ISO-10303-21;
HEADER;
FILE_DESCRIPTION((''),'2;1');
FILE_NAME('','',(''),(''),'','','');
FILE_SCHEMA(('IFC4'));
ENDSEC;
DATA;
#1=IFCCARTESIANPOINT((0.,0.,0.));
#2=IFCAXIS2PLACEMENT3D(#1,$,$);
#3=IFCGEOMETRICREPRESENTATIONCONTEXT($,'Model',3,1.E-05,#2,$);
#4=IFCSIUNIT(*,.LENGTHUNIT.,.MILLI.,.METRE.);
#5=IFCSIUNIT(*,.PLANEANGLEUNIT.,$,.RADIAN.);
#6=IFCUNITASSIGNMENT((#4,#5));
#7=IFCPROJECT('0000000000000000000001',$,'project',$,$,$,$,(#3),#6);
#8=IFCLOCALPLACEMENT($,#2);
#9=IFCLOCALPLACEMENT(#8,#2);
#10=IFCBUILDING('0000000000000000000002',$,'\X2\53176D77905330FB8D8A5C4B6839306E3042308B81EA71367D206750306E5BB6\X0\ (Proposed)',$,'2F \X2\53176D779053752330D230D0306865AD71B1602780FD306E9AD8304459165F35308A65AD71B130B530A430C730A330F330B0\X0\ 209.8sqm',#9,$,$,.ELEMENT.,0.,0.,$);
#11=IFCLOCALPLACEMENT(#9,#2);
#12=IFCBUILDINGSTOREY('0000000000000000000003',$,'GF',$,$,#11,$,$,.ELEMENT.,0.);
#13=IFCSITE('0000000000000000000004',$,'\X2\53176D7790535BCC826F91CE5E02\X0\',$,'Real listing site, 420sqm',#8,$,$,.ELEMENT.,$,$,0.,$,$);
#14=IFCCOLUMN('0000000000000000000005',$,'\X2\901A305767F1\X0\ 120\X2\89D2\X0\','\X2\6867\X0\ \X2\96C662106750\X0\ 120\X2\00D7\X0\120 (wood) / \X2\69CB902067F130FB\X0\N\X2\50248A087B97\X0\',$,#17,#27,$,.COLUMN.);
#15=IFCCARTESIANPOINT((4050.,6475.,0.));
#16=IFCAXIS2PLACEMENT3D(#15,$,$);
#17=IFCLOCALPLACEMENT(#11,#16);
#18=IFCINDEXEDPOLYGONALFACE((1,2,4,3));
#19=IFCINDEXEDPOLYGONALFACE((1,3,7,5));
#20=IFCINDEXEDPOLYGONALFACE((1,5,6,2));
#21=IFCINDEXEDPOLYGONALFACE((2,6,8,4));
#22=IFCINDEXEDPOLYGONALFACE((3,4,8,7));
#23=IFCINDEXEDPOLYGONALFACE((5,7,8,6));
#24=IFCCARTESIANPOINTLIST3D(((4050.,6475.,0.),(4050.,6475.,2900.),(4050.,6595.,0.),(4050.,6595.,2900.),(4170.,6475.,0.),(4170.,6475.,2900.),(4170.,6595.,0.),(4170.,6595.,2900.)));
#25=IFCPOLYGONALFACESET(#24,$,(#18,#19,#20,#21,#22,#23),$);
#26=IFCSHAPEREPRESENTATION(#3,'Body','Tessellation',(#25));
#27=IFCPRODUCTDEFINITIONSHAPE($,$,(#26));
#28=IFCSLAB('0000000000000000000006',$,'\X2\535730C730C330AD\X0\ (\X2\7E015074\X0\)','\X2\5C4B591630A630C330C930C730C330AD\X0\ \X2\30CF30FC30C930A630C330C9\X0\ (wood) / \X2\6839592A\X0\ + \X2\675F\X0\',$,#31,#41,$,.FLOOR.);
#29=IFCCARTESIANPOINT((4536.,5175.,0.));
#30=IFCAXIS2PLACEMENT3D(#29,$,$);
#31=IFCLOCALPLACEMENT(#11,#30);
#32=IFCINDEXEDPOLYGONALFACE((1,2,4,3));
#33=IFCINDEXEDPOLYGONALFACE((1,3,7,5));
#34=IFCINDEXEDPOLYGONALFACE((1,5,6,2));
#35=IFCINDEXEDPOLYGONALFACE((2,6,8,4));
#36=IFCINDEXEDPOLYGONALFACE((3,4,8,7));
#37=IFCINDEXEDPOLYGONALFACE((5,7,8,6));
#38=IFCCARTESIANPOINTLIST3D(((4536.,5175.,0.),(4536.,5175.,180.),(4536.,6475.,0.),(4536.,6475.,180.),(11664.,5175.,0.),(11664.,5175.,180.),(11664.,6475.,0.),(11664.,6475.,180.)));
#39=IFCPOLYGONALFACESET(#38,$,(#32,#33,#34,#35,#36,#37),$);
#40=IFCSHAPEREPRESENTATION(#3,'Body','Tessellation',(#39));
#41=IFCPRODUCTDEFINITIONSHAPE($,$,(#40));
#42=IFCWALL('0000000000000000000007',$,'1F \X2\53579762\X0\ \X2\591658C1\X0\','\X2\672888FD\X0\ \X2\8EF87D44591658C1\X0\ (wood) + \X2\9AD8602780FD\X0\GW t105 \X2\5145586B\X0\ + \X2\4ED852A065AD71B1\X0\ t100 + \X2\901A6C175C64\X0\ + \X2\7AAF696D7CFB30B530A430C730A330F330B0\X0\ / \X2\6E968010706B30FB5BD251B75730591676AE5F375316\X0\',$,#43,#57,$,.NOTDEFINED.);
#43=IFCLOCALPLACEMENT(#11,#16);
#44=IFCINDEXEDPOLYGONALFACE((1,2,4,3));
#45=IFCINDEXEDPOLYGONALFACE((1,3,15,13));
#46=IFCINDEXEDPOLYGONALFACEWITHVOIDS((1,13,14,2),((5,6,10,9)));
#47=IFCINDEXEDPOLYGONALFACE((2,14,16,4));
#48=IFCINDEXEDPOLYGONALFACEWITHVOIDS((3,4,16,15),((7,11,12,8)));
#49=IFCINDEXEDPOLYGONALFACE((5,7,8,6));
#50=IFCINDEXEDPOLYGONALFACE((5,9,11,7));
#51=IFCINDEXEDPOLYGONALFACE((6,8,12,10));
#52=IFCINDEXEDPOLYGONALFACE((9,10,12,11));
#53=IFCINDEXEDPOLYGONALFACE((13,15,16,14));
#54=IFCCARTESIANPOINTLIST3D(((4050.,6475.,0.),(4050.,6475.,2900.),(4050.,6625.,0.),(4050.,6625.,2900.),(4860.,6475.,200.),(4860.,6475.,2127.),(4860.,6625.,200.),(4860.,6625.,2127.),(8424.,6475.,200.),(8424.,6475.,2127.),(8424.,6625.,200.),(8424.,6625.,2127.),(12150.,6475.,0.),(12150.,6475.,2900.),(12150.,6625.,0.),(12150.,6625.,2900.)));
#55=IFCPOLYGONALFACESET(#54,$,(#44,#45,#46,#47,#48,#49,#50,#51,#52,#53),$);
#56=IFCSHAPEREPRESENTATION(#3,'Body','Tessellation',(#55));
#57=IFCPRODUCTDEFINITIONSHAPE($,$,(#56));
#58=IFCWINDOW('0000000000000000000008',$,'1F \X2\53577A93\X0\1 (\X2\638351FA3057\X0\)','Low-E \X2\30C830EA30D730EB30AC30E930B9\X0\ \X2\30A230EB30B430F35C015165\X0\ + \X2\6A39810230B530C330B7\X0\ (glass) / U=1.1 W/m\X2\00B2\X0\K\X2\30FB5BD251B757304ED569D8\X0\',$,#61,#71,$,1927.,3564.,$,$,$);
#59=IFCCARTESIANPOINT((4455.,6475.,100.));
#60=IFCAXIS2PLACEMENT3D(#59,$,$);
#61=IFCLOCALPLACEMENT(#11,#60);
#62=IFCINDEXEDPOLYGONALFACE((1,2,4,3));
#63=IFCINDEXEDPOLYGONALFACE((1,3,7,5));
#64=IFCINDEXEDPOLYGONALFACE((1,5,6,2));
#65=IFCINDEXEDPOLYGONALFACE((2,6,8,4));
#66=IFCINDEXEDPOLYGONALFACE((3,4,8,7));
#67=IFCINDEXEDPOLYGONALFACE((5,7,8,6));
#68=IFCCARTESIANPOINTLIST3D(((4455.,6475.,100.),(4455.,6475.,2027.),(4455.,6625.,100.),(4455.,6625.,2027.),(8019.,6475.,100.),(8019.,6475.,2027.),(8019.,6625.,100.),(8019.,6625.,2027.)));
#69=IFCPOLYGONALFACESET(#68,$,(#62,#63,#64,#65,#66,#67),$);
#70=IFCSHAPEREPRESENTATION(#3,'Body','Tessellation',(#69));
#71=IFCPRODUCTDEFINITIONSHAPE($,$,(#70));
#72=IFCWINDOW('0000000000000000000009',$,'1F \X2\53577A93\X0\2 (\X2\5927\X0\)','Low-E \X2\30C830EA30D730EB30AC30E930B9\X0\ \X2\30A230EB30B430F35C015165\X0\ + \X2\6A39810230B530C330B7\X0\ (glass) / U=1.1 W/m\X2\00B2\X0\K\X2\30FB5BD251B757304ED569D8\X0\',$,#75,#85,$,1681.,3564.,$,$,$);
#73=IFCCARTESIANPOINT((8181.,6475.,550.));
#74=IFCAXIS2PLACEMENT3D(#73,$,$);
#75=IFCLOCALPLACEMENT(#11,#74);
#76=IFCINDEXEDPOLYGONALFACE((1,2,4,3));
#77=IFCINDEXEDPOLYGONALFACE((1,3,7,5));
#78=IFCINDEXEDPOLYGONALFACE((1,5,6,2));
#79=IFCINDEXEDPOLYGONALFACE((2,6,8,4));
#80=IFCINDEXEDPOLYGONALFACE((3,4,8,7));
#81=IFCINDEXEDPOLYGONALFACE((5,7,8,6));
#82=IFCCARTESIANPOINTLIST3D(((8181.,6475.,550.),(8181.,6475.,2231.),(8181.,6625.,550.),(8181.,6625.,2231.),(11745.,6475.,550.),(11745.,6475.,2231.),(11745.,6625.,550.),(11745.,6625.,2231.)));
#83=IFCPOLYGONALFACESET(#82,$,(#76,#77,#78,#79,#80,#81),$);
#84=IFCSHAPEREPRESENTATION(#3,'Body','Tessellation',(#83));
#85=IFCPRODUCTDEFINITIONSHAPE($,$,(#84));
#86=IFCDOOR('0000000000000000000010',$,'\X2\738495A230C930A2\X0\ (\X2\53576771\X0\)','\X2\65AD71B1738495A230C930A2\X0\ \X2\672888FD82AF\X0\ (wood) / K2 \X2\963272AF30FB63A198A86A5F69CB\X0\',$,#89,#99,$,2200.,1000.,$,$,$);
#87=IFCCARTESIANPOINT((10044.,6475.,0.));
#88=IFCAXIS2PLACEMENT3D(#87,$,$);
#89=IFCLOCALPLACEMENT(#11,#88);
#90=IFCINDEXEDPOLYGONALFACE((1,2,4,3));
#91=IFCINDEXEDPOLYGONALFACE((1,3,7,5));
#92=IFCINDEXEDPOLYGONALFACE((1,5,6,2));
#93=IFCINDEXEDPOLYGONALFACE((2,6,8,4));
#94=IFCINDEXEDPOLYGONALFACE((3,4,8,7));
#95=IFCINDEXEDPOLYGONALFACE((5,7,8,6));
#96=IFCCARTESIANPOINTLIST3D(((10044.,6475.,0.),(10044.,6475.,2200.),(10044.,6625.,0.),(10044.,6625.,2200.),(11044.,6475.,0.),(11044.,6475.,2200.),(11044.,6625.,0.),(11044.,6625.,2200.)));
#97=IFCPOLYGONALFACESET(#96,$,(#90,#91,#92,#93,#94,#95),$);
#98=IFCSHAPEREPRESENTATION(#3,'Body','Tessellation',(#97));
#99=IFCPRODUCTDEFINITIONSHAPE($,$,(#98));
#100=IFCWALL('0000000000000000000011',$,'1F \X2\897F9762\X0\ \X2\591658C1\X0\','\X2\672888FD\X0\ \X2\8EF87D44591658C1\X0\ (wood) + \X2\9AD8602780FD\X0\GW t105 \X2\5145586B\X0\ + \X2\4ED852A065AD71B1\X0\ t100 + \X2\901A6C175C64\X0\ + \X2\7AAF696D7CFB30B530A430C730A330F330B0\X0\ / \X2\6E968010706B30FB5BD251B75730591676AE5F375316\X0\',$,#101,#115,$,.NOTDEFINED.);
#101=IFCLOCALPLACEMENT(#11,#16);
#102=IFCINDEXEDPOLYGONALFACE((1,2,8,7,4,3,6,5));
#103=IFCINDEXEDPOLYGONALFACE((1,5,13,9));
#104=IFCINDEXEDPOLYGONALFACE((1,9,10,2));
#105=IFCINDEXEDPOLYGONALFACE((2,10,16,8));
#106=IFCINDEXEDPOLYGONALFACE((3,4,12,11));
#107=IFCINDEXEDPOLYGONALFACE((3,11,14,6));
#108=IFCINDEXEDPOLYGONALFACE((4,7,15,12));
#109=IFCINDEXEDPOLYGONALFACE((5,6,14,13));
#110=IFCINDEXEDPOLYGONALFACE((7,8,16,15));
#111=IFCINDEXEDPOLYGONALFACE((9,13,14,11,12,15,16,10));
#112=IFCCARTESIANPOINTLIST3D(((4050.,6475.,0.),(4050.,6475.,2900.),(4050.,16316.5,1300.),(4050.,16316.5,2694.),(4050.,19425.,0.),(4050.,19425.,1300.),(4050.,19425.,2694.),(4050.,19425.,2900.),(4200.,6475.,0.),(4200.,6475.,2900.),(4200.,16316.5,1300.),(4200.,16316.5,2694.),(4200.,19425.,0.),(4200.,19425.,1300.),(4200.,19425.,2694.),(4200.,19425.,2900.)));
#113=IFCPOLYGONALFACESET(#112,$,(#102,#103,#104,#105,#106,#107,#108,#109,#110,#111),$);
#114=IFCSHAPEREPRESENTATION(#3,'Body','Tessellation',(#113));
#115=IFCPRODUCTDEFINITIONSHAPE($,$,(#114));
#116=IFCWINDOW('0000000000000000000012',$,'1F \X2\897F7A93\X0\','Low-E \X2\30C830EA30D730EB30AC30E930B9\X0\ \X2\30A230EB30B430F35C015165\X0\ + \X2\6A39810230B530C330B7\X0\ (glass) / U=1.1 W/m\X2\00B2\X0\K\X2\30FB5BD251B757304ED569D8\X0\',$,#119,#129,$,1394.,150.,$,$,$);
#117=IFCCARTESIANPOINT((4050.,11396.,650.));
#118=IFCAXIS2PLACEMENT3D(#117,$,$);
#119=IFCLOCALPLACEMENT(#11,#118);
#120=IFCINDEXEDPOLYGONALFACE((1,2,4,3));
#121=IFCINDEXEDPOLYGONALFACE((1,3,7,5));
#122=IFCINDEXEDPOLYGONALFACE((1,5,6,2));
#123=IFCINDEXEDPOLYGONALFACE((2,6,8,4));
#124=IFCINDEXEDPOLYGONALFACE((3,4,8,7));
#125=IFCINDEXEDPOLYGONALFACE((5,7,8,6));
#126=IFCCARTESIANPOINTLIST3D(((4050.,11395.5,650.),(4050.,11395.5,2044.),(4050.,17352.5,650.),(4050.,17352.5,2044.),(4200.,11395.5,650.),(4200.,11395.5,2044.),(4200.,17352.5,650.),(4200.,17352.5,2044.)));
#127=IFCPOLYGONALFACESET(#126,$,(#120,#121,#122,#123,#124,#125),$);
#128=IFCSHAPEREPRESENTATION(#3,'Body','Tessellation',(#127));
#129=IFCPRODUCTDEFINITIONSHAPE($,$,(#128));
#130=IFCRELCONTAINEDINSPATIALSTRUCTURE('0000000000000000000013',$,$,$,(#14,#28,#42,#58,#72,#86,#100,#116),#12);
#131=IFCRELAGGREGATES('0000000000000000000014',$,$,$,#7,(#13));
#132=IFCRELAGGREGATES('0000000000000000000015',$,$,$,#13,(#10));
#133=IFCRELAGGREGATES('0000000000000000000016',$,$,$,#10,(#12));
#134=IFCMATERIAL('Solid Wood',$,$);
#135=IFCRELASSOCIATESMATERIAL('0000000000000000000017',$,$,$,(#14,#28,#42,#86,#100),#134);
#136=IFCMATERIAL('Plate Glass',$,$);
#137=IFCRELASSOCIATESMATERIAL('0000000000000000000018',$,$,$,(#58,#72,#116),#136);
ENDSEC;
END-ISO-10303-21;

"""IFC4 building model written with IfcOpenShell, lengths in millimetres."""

from ifc_helpers import new_model, si_unit, frame, frame_2d, origin, place, context, project, spatial, rectangle, extrude, material, element, fill, save


model = new_model("IFC4")

# Units and contexts
model_context = context("Model", 3, precision=1e-05, world=origin())
ifc_project = project(units=[si_unit("LENGTHUNIT", "METRE", prefix="MILLI"), si_unit("PLANEANGLEUNIT", "RADIAN")], contexts=[model_context])

# Site, building, storey
site_placement = place(None, origin())
site = spatial("IfcSite", under=ifc_project, at=site_placement, Name="北海道富良野市", ObjectType="Real listing site, 420sqm", CompositionType="ELEMENT", RefElevation=0.0)
building_placement = place(site_placement, origin())
building = spatial("IfcBuilding", under=site, at=building_placement, Name="北海道・越屋根のある自然素材の家 (Proposed)", ObjectType="2F 北海道産ヒバと断熱性能の高い外張り断熱サイディング 209.8sqm", CompositionType="ELEMENT", ElevationOfRefHeight=0.0, ElevationOfTerrain=0.0)
storey_placement = place(building_placement, origin())
storey = spatial("IfcBuildingStorey", under=building, at=storey_placement, Name="GF", CompositionType="ELEMENT", Elevation=0.0)

# Column
ifc_material_1 = material(Name="Solid Wood")
column_placement = place(storey_placement, frame((4050.0, 6475.0, 0.0)))
element("IfcColumn", 1, at=column_placement, inside=storey, material=ifc_material_1, Name="通し柱 120角", Description="桧 集成材 120×120 (wood) / 構造柱・N値計算", PredefinedType="COLUMN", context=model_context, shape_type="SweptSolid", body=[
    extrude(rectangle(XDim=120.0, YDim=120.0, at=frame_2d((60.0, 60.0))), frame((4050.0, 6475.0, 0.0)), (0.0, 0.0, 1.0), 2900.0),
])

# Slab
slab_1_placement = place(storey_placement, frame((4536.0, 5175.0, 0.0)))
element("IfcSlab", 2, at=slab_1_placement, inside=storey, material=ifc_material_1, Name="南デッキ (縁側)", Description="屋外ウッドデッキ ハードウッド (wood) / 根太 + 束", PredefinedType="FLOOR", context=model_context, shape_type="SweptSolid", body=[
    extrude(rectangle(XDim=7128.0, YDim=1300.0, at=frame_2d((3564.0, 650.0))), frame((4536.0, 5175.0, 0.0)), (0.0, 0.0, 1.0), 180.0),
])

# Wall, openings, windows, door
wall_1_placement = place(storey_placement, frame((4050.0, 6475.0, 0.0)))
wall_1 = element("IfcWall", 3, at=wall_1_placement, inside=storey, material=ifc_material_1, Name="1F 南面 外壁", Description="木製 軸組外壁 (wood) + 高性能GW t105 充填 + 付加断熱 t100 + 通気層 + 窯業系サイディング / 準耐火・寒冷地外皮強化", PredefinedType="NOTDEFINED", context=model_context, shape_type="SweptSolid", body=[
    extrude(rectangle(XDim=8100.0, YDim=150.0, at=frame_2d((4050.0, 75.0))), frame((4050.0, 6475.0, 0.0)), (0.0, 0.0, 1.0), 2900.0),
])
opening_1_placement = place(storey_placement, frame((4455.0, 6475.0, 100.0)))
opening_1 = element("IfcOpeningElement", 4, at=opening_1_placement, cuts=wall_1, PredefinedType="NOTDEFINED", context=model_context, shape_type="SweptSolid", body=[
    extrude(rectangle(XDim=3564.0, YDim=150.0, at=frame_2d((1782.0, 75.0))), frame((4455.0, 6475.0, 100.0)), (0.0, 0.0, 1.0), 1927.0),
])
opening_2_placement = place(storey_placement, frame((8181.0, 6475.0, 550.0)))
opening_2 = element("IfcOpeningElement", 5, at=opening_2_placement, cuts=wall_1, PredefinedType="NOTDEFINED", context=model_context, shape_type="SweptSolid", body=[
    extrude(rectangle(XDim=3564.0, YDim=150.0, at=frame_2d((1782.0, 75.0))), frame((8181.0, 6475.0, 550.0)), (0.0, 0.0, 1.0), 1681.0),
])
opening_3_placement = place(storey_placement, frame((10044.0, 6475.0, 0.0)))
opening_3 = element("IfcOpeningElement", 6, at=opening_3_placement, cuts=wall_1, PredefinedType="NOTDEFINED", context=model_context, shape_type="SweptSolid", body=[
    extrude(rectangle(XDim=1000.0, YDim=150.0, at=frame_2d((500.0, 75.0))), frame((10044.0, 6475.0, 0.0)), (0.0, 0.0, 1.0), 2200.0),
])
ifc_material_2 = material(Name="Plate Glass")
window_1_placement = place(storey_placement, frame((4455.0, 6475.0, 100.0)))
window_1 = element("IfcWindow", 7, at=window_1_placement, inside=storey, material=ifc_material_2, Name="1F 南窓1 (掃出し)", Description="Low-E トリプルガラス アルゴン封入 + 樹脂サッシ (glass) / U=1.1 W/m²K・寒冷地仕様", OverallHeight=1927.0, OverallWidth=3564.0, context=model_context, shape_type="SweptSolid", body=[
    extrude(rectangle(XDim=3564.0, YDim=150.0, at=frame_2d((1782.0, 75.0))), frame((4455.0, 6475.0, 100.0)), (0.0, 0.0, 1.0), 1927.0),
])
fill(opening_1, window_1)
window_2_placement = place(storey_placement, frame((8181.0, 6475.0, 550.0)))
window_2 = element("IfcWindow", 8, at=window_2_placement, inside=storey, material=ifc_material_2, Name="1F 南窓2 (大)", Description="Low-E トリプルガラス アルゴン封入 + 樹脂サッシ (glass) / U=1.1 W/m²K・寒冷地仕様", OverallHeight=1681.0, OverallWidth=3564.0, context=model_context, shape_type="SweptSolid", body=[
    extrude(rectangle(XDim=3564.0, YDim=150.0, at=frame_2d((1782.0, 75.0))), frame((8181.0, 6475.0, 550.0)), (0.0, 0.0, 1.0), 1681.0),
])
fill(opening_2, window_2)
door_placement = place(storey_placement, frame((10044.0, 6475.0, 0.0)))
door = element("IfcDoor", 9, at=door_placement, inside=storey, material=ifc_material_1, Name="玄関ドア (南東)", Description="断熱玄関ドア 木製芯 (wood) / K2 防犯・採風機構", OverallHeight=2200.0, OverallWidth=1000.0, context=model_context, shape_type="SweptSolid", body=[
    extrude(rectangle(XDim=1000.0, YDim=150.0, at=frame_2d((500.0, 75.0))), frame((10044.0, 6475.0, 0.0)), (0.0, 0.0, 1.0), 2200.0),
])
fill(opening_3, door)

# Wall, opening, window
wall_2_placement = place(storey_placement, frame((4050.0, 6475.0, 0.0)))
wall_2 = element("IfcWall", 10, at=wall_2_placement, inside=storey, material=ifc_material_1, Name="1F 西面 外壁", Description="木製 軸組外壁 (wood) + 高性能GW t105 充填 + 付加断熱 t100 + 通気層 + 窯業系サイディング / 準耐火・寒冷地外皮強化", PredefinedType="NOTDEFINED", context=model_context, shape_type="SweptSolid", body=[
    extrude(rectangle(XDim=150.0, YDim=12950.0, at=frame_2d((75.0, 6475.0))), frame((4050.0, 6475.0, 0.0)), (0.0, 0.0, 1.0), 2900.0),
])
opening_4_placement = place(storey_placement, frame((4050.0, 11396.0, 650.0)))
opening_4 = element("IfcOpeningElement", 11, at=opening_4_placement, cuts=wall_2, PredefinedType="NOTDEFINED", context=model_context, shape_type="SweptSolid", body=[
    extrude(rectangle(XDim=150.0, YDim=5957.0, at=frame_2d((75.0, 2978.0))), frame((4050.0, 11396.0, 650.0)), (0.0, 0.0, 1.0), 1394.0),
])
window_3_placement = place(storey_placement, frame((4050.0, 11396.0, 650.0)))
window_3 = element("IfcWindow", 12, at=window_3_placement, inside=storey, material=ifc_material_2, Name="1F 西窓", Description="Low-E トリプルガラス アルゴン封入 + 樹脂サッシ (glass) / U=1.1 W/m²K・寒冷地仕様", OverallHeight=1394.0, OverallWidth=150.0, context=model_context, shape_type="SweptSolid", body=[
    extrude(rectangle(XDim=150.0, YDim=5957.0, at=frame_2d((75.0, 2978.0))), frame((4050.0, 11396.0, 650.0)), (0.0, 0.0, 1.0), 1394.0),
])
fill(opening_4, window_3)

save(model, "model.ifc")
